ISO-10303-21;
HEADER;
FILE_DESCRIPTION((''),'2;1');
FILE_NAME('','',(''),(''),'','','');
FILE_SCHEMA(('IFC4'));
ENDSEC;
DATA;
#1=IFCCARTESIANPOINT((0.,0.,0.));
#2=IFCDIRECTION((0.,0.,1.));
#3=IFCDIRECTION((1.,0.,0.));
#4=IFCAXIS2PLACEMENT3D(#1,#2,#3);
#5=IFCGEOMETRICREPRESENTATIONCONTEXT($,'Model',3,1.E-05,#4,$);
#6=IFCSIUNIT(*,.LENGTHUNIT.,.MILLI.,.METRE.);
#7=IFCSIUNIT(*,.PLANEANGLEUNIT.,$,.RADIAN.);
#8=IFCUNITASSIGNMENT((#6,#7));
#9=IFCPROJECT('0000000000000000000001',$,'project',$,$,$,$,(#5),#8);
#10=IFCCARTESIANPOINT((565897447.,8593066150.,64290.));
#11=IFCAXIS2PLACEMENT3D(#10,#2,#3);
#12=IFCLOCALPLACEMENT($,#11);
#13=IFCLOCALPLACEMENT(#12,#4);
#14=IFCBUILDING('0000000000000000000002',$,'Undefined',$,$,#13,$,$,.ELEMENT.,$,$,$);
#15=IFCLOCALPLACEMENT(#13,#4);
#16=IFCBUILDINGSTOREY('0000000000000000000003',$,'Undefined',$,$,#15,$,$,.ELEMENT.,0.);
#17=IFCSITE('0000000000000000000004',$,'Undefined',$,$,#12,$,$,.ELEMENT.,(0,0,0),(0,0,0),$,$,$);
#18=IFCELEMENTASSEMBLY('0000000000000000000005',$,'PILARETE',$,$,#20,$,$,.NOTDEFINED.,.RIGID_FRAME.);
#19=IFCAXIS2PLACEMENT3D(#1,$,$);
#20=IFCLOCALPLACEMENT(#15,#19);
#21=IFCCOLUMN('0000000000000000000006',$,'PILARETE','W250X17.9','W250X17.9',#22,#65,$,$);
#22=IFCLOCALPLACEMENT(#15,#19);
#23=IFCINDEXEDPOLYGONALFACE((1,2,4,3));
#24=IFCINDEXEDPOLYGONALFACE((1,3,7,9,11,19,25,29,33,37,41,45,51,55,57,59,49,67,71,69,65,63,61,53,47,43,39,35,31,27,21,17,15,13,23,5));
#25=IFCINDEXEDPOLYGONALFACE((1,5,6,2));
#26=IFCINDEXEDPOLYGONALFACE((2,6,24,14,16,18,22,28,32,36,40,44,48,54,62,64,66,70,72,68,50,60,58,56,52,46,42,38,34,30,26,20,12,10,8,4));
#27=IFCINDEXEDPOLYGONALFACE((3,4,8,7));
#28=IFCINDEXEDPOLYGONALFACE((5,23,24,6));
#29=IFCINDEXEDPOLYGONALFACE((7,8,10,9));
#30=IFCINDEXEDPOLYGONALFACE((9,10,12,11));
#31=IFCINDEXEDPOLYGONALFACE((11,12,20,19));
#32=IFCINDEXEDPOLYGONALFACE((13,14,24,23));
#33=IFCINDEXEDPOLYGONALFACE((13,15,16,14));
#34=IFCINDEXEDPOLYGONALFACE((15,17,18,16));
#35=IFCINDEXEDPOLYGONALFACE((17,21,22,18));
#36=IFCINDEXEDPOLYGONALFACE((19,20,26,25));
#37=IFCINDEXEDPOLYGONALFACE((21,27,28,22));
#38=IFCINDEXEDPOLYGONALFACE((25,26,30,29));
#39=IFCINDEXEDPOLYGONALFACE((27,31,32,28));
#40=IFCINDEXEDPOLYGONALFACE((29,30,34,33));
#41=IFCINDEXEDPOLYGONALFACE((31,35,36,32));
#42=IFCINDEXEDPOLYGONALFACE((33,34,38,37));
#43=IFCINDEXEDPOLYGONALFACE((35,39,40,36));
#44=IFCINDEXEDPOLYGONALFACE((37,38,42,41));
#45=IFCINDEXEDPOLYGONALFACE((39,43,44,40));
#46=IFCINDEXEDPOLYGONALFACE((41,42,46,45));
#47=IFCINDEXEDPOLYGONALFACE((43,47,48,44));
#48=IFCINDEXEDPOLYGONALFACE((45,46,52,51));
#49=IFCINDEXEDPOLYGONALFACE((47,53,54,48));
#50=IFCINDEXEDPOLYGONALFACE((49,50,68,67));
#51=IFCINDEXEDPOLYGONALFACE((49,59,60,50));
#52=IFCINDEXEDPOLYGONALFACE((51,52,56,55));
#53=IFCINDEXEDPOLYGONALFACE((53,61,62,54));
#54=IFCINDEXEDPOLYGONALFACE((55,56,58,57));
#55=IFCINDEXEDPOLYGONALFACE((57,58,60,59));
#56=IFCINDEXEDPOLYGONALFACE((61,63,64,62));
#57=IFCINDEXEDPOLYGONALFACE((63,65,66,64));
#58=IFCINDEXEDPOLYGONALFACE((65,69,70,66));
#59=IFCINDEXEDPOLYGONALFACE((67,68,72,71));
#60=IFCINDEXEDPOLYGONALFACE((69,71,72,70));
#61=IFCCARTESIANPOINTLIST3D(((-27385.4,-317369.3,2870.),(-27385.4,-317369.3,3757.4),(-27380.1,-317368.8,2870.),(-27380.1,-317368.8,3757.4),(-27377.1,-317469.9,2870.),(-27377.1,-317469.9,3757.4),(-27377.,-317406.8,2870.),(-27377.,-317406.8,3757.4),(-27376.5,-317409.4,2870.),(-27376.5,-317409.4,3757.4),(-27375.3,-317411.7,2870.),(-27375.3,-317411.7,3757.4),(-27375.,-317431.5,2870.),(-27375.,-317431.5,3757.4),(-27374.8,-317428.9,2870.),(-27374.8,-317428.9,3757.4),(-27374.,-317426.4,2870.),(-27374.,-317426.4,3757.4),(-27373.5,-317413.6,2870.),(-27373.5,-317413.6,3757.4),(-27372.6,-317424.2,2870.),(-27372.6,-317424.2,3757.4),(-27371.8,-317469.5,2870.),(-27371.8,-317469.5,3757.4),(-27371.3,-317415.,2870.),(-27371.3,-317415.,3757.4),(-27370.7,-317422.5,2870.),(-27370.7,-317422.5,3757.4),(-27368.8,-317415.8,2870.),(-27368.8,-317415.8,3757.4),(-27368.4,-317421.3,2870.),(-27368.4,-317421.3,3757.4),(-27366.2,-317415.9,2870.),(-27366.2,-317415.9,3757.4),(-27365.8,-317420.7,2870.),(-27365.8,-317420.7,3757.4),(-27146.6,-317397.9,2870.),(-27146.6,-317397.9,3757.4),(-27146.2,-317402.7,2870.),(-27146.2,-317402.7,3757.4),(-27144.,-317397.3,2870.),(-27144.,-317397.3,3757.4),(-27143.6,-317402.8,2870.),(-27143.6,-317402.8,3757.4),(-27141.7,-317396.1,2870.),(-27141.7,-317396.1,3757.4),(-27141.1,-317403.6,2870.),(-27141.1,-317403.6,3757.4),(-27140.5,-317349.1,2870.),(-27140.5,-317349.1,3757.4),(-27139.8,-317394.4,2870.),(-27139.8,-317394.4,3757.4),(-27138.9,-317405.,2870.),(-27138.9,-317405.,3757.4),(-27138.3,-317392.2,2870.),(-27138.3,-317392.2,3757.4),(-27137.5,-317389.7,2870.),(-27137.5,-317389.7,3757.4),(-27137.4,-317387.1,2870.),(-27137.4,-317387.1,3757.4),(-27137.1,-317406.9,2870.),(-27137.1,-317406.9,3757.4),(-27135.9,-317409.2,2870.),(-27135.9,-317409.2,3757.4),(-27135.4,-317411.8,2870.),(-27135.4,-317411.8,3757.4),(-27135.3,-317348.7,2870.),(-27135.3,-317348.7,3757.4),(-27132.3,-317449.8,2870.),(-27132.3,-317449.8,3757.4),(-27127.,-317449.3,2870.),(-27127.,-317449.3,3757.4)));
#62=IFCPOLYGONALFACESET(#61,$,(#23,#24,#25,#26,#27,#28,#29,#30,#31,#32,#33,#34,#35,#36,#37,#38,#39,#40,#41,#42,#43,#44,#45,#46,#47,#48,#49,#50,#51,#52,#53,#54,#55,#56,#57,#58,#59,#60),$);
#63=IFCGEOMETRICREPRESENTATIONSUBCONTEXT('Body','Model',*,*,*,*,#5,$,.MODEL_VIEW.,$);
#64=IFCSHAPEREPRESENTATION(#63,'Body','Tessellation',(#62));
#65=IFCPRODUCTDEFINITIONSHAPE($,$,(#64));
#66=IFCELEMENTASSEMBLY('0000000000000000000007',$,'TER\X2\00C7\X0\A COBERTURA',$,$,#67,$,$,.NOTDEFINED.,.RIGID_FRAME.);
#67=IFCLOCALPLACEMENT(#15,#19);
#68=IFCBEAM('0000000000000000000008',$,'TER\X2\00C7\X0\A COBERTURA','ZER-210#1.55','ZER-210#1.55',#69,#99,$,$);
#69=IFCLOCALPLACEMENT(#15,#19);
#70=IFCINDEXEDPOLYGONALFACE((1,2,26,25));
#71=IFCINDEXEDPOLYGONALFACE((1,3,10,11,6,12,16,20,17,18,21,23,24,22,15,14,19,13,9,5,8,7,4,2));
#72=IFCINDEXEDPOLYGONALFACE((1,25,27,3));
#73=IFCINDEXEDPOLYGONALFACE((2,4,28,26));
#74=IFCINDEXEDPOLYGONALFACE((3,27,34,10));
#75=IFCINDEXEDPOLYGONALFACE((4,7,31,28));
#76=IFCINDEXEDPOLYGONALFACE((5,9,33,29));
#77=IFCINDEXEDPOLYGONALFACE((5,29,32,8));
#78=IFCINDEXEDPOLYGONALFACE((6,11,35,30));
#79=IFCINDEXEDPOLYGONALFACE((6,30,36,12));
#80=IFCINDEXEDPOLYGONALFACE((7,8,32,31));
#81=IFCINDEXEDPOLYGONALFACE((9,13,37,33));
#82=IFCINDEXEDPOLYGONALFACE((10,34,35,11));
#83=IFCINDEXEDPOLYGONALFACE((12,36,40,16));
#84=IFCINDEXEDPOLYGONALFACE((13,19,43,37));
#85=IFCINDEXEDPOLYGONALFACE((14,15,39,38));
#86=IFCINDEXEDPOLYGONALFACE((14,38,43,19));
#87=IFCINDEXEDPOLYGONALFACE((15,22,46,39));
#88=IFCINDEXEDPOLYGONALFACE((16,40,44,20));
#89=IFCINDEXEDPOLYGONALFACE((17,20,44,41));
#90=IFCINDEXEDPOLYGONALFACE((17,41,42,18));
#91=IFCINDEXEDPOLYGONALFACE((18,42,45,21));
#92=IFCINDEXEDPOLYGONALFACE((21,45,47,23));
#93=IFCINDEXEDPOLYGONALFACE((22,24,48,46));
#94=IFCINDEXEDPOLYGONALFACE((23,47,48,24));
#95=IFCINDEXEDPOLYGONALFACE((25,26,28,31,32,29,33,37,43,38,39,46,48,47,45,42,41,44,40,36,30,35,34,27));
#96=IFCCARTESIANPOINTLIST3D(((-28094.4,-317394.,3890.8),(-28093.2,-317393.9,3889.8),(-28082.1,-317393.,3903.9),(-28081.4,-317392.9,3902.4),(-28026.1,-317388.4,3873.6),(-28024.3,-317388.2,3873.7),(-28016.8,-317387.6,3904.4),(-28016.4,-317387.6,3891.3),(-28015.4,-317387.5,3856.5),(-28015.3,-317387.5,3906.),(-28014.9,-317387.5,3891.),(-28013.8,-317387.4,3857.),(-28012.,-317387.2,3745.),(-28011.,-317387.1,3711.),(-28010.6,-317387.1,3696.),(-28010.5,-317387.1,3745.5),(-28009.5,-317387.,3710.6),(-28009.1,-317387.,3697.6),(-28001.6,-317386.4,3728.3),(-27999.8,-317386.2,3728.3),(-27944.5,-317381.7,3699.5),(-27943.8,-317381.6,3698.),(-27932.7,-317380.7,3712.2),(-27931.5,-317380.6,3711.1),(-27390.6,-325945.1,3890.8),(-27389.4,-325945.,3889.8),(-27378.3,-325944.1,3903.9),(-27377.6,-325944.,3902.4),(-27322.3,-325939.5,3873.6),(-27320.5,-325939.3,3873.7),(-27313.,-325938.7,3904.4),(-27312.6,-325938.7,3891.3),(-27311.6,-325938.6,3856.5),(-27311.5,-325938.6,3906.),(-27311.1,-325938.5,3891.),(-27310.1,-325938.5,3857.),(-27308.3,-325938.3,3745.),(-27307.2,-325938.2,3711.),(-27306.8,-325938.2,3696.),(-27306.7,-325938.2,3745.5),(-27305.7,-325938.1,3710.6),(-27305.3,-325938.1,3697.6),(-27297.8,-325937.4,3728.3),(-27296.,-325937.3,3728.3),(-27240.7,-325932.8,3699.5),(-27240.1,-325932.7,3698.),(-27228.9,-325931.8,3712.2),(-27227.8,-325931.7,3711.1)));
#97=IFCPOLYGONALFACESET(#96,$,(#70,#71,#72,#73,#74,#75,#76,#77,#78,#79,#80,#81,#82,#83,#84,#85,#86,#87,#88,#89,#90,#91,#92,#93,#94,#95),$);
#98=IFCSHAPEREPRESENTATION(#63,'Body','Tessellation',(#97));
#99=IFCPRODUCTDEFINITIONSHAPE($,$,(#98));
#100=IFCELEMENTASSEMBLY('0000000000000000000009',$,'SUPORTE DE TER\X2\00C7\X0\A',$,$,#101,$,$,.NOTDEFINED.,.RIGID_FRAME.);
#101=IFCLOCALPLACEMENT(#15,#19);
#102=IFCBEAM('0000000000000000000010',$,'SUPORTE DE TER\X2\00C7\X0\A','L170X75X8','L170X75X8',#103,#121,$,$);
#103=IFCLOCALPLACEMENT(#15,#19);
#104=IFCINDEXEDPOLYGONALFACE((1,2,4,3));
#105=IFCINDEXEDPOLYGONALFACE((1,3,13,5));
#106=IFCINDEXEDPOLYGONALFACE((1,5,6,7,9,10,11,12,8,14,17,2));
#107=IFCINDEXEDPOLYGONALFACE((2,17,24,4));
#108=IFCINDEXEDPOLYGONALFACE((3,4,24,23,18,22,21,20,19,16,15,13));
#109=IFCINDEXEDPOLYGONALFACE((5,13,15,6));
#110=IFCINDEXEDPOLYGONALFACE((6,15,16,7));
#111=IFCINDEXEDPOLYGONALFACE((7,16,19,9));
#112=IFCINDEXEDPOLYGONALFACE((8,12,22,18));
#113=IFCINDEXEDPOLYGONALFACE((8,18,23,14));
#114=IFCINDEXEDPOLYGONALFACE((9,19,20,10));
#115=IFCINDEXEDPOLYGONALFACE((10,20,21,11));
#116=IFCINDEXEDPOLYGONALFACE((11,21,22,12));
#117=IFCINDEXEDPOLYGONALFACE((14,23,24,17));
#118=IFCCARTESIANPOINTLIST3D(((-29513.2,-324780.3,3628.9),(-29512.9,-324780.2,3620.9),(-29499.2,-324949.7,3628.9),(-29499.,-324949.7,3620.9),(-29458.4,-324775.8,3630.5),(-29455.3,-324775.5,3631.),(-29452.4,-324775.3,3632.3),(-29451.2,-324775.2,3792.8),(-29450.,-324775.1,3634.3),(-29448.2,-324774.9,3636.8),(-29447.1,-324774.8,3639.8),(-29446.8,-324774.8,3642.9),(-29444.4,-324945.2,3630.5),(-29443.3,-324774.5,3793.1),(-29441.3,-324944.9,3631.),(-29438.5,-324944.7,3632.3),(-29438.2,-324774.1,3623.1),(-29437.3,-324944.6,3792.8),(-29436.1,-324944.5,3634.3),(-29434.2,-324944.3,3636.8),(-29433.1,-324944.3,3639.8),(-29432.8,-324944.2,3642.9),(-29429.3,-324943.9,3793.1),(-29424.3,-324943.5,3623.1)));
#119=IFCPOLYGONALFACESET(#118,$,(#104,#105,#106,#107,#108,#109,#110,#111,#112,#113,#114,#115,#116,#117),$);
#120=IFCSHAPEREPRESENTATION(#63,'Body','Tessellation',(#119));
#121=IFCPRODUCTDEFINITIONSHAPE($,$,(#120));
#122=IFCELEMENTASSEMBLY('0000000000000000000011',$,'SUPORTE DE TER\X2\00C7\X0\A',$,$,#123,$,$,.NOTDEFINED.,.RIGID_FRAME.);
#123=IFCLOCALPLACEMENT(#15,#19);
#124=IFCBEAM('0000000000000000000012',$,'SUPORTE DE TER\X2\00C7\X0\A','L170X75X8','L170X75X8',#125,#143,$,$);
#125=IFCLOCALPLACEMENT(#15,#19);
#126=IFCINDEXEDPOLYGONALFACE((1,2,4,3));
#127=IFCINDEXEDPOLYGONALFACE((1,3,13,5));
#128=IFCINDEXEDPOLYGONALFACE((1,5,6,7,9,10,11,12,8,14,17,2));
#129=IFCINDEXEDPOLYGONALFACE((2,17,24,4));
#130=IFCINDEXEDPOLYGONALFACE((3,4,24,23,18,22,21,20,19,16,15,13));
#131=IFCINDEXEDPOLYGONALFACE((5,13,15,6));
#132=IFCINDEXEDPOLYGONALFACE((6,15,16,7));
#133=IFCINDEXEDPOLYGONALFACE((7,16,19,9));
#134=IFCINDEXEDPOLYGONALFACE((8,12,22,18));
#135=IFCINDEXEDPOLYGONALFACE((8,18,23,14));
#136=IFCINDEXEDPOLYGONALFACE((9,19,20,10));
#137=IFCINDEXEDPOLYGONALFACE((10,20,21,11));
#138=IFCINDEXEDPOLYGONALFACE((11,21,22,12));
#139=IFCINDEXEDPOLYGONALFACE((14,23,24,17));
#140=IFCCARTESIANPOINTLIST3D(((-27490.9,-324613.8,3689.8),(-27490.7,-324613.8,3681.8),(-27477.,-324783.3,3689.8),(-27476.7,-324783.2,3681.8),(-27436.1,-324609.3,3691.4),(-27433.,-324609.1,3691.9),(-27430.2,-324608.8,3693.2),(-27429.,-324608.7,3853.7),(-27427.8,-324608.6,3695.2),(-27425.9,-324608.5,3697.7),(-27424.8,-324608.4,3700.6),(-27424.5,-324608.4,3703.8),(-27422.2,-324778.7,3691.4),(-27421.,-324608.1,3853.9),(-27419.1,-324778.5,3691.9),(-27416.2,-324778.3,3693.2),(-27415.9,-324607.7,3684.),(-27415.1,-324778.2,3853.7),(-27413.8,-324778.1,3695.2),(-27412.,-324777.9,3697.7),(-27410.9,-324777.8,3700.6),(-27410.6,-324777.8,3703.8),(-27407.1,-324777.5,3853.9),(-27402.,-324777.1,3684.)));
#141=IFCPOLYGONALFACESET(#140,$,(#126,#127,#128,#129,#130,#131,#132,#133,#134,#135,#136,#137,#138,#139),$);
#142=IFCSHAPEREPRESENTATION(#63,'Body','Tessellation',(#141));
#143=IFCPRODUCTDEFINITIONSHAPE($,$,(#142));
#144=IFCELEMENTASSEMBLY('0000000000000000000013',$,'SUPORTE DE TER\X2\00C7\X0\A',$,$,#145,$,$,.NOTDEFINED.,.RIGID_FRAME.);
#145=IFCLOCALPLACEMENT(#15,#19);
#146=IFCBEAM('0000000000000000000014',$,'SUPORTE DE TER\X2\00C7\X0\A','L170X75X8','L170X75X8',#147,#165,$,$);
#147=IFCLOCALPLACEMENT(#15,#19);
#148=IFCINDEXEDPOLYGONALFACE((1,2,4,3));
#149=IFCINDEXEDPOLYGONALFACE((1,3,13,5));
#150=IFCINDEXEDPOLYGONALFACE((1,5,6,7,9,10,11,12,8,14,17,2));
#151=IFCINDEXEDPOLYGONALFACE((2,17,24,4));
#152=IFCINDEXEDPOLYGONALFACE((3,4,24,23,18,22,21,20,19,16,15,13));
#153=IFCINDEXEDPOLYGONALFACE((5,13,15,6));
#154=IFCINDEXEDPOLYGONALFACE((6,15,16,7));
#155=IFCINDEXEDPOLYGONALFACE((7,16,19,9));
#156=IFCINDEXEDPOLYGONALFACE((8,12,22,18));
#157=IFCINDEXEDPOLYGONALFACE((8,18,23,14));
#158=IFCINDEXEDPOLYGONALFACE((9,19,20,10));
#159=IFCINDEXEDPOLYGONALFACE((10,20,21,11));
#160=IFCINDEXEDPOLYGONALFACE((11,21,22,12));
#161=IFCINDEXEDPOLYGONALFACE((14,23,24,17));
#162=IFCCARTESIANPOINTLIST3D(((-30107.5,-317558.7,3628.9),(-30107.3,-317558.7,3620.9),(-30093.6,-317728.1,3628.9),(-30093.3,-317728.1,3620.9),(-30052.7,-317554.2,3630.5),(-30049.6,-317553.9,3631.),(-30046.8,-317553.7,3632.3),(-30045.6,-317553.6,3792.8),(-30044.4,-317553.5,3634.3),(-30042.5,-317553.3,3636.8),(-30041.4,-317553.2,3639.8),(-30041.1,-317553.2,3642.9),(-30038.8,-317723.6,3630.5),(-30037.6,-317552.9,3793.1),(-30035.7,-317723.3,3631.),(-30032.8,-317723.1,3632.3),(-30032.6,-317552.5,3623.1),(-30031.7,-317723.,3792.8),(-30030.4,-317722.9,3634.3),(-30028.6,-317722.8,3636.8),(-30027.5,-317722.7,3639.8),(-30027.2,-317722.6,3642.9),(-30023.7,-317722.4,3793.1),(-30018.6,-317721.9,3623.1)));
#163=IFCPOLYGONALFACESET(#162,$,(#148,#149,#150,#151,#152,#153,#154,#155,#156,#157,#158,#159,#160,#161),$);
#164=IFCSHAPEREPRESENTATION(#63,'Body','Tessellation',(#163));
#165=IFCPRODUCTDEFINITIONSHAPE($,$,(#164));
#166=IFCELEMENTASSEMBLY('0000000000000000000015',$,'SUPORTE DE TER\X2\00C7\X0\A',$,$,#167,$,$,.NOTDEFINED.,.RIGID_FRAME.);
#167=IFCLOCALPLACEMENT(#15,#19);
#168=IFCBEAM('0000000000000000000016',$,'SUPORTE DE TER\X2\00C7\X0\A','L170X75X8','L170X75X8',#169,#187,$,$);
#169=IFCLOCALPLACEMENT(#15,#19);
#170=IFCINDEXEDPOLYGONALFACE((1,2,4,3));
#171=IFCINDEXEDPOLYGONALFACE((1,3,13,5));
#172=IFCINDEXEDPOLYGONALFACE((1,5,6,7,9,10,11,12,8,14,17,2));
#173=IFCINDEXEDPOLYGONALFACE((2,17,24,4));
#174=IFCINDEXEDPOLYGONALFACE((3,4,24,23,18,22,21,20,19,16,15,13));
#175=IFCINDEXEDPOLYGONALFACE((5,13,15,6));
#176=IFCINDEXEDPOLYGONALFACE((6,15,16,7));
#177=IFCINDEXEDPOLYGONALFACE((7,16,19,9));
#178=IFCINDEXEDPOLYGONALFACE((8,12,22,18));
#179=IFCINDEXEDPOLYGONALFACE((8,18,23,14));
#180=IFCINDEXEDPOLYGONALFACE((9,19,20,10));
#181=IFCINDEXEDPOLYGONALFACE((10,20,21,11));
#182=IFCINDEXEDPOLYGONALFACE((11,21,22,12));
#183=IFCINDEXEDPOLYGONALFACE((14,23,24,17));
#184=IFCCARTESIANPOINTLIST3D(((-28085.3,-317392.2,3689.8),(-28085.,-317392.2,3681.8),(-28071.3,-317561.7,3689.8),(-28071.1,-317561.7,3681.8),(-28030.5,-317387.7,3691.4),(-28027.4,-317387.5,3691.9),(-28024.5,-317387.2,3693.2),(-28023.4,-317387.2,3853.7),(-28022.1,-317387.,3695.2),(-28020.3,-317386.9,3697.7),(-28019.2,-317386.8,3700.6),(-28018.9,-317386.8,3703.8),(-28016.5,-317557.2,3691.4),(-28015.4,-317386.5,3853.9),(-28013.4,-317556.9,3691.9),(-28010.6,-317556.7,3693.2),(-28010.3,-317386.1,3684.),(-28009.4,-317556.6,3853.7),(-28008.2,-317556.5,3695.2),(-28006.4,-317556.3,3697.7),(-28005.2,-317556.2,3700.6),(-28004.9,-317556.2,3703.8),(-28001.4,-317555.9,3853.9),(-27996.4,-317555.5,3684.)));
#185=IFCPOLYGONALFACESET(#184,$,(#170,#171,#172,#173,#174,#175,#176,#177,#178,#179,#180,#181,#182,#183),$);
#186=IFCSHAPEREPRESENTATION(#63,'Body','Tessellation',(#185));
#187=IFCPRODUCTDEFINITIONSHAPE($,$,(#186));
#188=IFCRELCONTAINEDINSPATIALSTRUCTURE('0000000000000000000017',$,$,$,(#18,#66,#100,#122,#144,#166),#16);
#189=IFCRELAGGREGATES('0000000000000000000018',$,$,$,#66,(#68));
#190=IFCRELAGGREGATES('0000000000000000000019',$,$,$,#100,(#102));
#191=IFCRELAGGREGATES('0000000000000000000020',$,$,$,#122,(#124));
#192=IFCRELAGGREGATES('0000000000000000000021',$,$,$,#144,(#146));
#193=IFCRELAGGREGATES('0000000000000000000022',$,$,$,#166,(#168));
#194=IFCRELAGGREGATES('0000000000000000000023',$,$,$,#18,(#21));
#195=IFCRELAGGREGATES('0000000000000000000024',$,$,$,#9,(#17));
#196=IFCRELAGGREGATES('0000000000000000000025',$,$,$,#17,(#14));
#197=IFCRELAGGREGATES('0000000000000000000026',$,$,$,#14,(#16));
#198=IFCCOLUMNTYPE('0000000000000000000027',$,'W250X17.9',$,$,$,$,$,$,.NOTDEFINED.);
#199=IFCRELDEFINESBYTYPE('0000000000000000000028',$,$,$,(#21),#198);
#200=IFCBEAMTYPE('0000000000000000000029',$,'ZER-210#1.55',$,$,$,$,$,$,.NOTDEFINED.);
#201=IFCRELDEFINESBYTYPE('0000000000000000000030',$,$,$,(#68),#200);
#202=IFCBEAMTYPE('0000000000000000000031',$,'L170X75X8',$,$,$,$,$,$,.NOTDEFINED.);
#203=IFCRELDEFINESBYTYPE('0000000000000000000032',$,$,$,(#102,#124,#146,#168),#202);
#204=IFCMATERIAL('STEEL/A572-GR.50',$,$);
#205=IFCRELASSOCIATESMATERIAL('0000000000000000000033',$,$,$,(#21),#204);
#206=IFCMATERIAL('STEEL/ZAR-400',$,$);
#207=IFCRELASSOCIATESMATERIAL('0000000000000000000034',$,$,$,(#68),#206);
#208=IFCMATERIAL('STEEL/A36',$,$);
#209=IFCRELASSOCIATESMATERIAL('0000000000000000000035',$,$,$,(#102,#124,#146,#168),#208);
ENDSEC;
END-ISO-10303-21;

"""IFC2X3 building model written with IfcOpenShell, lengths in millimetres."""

from ifc_helpers import new_model, si_unit, frame, origin_with_axes, origin_2d_with_axis, place, context, subcontext, project, spatial, polyline, i_section, l_section, outline, extrude, material, type_object, element, aggregate, save


model = new_model("IFC2X3")

# Units and contexts
model_context = context("Model", 3, precision=1e-05, world=origin_with_axes())
body_context = subcontext(model_context, "Body", "Model", "MODEL_VIEW")
ifc_project = project(units=[si_unit("LENGTHUNIT", "METRE", prefix="MILLI"), si_unit("PLANEANGLEUNIT", "RADIAN")], contexts=[model_context])

# Site, building, storey
site_placement = place(None, frame((565897447.0, 8593066150.0, 64290.0), z_axis=(0.0, 0.0, 1.0), x_axis=(1.0, 0.0, 0.0)))
site = spatial("IfcSite", under=ifc_project, at=site_placement, Name="Undefined", CompositionType="ELEMENT", RefLatitude=(0, 0, 0), RefLongitude=(0, 0, 0))
building_placement = place(site_placement, origin_with_axes())
building = spatial("IfcBuilding", under=site, at=building_placement, Name="Undefined", CompositionType="ELEMENT")
storey_placement = place(building_placement, origin_with_axes())
storey = spatial("IfcBuildingStorey", under=building, at=storey_placement, Name="Undefined", CompositionType="ELEMENT", Elevation=0.0)

# Element assembly, column
assembly_1_placement = place(storey_placement, origin_with_axes())
assembly_1 = element("IfcElementAssembly", 1, at=assembly_1_placement, inside=storey, Name="PILARETE", AssemblyPlace="NOTDEFINED", PredefinedType="RIGID_FRAME")
ifc_material_1 = material(Name="STEEL/A572-GR.50")
column_type = type_object("IfcColumnType", Name="W250X17.9", PredefinedType="NOTDEFINED")
column_placement = place(assembly_1_placement, frame((-27256.2, -317409.3, 2870.0), z_axis=(0.0, 0.0, 1.0), x_axis=(0.99663, 0.082025, 0.0)))
column = element("IfcColumn", 2, at=column_placement, type_object=column_type, material=ifc_material_1, Name="PILARETE", Description="W250X17.9", ObjectType="W250X17.9", context=body_context, shape_type="SweptSolid", body=[
    extrude(i_section(OverallWidth=101.0, OverallDepth=251.0, WebThickness=4.8, FlangeThickness=5.3, FilletRadius=10.0, at=origin_2d_with_axis()), frame((0.0, 0.0, 887.4), z_axis=(0.0, 0.0, -1.0), x_axis=(0.0, 1.0, 0.0)), (0.0, 0.0, 1.0), 887.4),
])

# Element assemblies, beams
assembly_2_placement = place(storey_placement, origin_with_axes())
assembly_2 = element("IfcElementAssembly", 3, at=assembly_2_placement, inside=storey, Name="TERÇA COBERTURA", AssemblyPlace="NOTDEFINED", PredefinedType="RIGID_FRAME")
ifc_material_2 = material(Name="STEEL/ZAR-400")
beam_type_1 = type_object("IfcBeamType", Name="ZER-210#1.55", PredefinedType="NOTDEFINED")
beam_1_placement = place(assembly_2_placement, frame((-27309.2, -325938.4, 3801.0), z_axis=(-0.029885, -0.00246, 0.99955), x_axis=(-0.082025, 0.99663, 0.0)))
beam_1 = element("IfcBeam", 4, at=beam_1_placement, type_object=beam_type_1, material=ifc_material_2, Name="TERÇA COBERTURA", Description="ZER-210#1.55", ObjectType="ZER-210#1.55", context=body_context, shape_type="SweptSolid", body=[
    extrude(outline(polyline([(65.6, -103.4), (77.9, -91.2), (79.0, -92.3), (66.2, -105.0), (-0.8, -105.0), (-0.8, -90.0), (9.2, -73.0), (-0.8, -56.0), (-0.8, 55.6), (-11.0, 73.0), (-0.8, 90.4), (-0.8, 103.5), (-65.6, 103.4), (-77.9, 91.2), (-79.0, 92.3), (-66.2, 105.0), (0.8, 105.0), (0.8, 90.0), (-9.2, 73.0), (0.8, 56.0), (0.8, -55.6), (11.0, -73.0), (0.8, -90.4), (0.8, -103.5), (65.6, -103.4)])), frame((8580.0, 0.0, 0.0), z_axis=(-1.0, 0.0, 0.0), x_axis=(0.0, -1.0, 0.0)), (0.0, 0.0, 1.0), 8580.0),
])
aggregate(assembly_2, [beam_1])
assembly_3_placement = place(storey_placement, origin_with_axes())
assembly_3 = element("IfcElementAssembly", 5, at=assembly_3_placement, inside=storey, Name="SUPORTE DE TERÇA", AssemblyPlace="NOTDEFINED", PredefinedType="RIGID_FRAME")
ifc_material_3 = material(Name="STEEL/A36")
beam_type_2 = type_object("IfcBeamType", Name="L170X75X8", PredefinedType="NOTDEFINED")
beam_2_placement = place(assembly_3_placement, frame((-29478.1, -324777.4, 3707.0), z_axis=(-0.029885, -0.00246, 0.99955), x_axis=(0.082025, -0.99663, 0.0)))
beam_2 = element("IfcBeam", 6, at=beam_2_placement, type_object=beam_type_2, material=ifc_material_3, Name="SUPORTE DE TERÇA", Description="L170X75X8", ObjectType="L170X75X8", context=body_context, shape_type="SweptSolid", body=[
    extrude(l_section(Depth=170.0, Width=75.0, Thickness=8.0, FilletRadius=12.0, at=origin_2d_with_axis()), frame((170.0, 0.0, 0.0), z_axis=(-1.0, 0.0, 0.0), x_axis=(0.0, -1.0, 0.0)), (0.0, 0.0, 1.0), 170.0),
])
aggregate(assembly_3, [beam_2])
assembly_4_placement = place(storey_placement, origin_with_axes())
assembly_4 = element("IfcElementAssembly", 7, at=assembly_4_placement, inside=storey, Name="SUPORTE DE TERÇA", AssemblyPlace="NOTDEFINED", PredefinedType="RIGID_FRAME")
beam_3_placement = place(assembly_4_placement, frame((-27455.8, -324610.9, 3767.8), z_axis=(-0.029885, -0.00246, 0.99955), x_axis=(0.082025, -0.99663, 0.0)))
beam_3 = element("IfcBeam", 8, at=beam_3_placement, type_object=beam_type_2, material=ifc_material_3, Name="SUPORTE DE TERÇA", Description="L170X75X8", ObjectType="L170X75X8", context=body_context, shape_type="SweptSolid", body=[
    extrude(l_section(Depth=170.0, Width=75.0, Thickness=8.0, FilletRadius=12.0, at=origin_2d_with_axis()), frame((170.0, 0.0, 0.0), z_axis=(-1.0, 0.0, 0.0), x_axis=(0.0, -1.0, 0.0)), (0.0, 0.0, 1.0), 170.0),
])
aggregate(assembly_4, [beam_3])
assembly_5_placement = place(storey_placement, origin_with_axes())
assembly_5 = element("IfcElementAssembly", 9, at=assembly_5_placement, inside=storey, Name="SUPORTE DE TERÇA", AssemblyPlace="NOTDEFINED", PredefinedType="RIGID_FRAME")
beam_4_placement = place(assembly_5_placement, frame((-30072.5, -317555.8, 3707.0), z_axis=(-0.029885, -0.00246, 0.99955), x_axis=(0.082025, -0.99663, 0.0)))
beam_4 = element("IfcBeam", 10, at=beam_4_placement, type_object=beam_type_2, material=ifc_material_3, Name="SUPORTE DE TERÇA", Description="L170X75X8", ObjectType="L170X75X8", context=body_context, shape_type="SweptSolid", body=[
    extrude(l_section(Depth=170.0, Width=75.0, Thickness=8.0, FilletRadius=12.0, at=origin_2d_with_axis()), frame((170.0, 0.0, 0.0), z_axis=(-1.0, 0.0, 0.0), x_axis=(0.0, -1.0, 0.0)), (0.0, 0.0, 1.0), 170.0),
])
aggregate(assembly_5, [beam_4])
assembly_6_placement = place(storey_placement, origin_with_axes())
assembly_6 = element("IfcElementAssembly", 11, at=assembly_6_placement, inside=storey, Name="SUPORTE DE TERÇA", AssemblyPlace="NOTDEFINED", PredefinedType="RIGID_FRAME")
beam_5_placement = place(assembly_6_placement, frame((-28050.2, -317389.4, 3767.8), z_axis=(-0.029885, -0.00246, 0.99955), x_axis=(0.082025, -0.99663, 0.0)))
beam_5 = element("IfcBeam", 12, at=beam_5_placement, type_object=beam_type_2, material=ifc_material_3, Name="SUPORTE DE TERÇA", Description="L170X75X8", ObjectType="L170X75X8", context=body_context, shape_type="SweptSolid", body=[
    extrude(l_section(Depth=170.0, Width=75.0, Thickness=8.0, FilletRadius=12.0, at=origin_2d_with_axis()), frame((170.0, 0.0, 0.0), z_axis=(-1.0, 0.0, 0.0), x_axis=(0.0, -1.0, 0.0)), (0.0, 0.0, 1.0), 170.0),
])
aggregate(assembly_6, [beam_5])

aggregate(assembly_1, [column])

save(model, "model.ifc")
